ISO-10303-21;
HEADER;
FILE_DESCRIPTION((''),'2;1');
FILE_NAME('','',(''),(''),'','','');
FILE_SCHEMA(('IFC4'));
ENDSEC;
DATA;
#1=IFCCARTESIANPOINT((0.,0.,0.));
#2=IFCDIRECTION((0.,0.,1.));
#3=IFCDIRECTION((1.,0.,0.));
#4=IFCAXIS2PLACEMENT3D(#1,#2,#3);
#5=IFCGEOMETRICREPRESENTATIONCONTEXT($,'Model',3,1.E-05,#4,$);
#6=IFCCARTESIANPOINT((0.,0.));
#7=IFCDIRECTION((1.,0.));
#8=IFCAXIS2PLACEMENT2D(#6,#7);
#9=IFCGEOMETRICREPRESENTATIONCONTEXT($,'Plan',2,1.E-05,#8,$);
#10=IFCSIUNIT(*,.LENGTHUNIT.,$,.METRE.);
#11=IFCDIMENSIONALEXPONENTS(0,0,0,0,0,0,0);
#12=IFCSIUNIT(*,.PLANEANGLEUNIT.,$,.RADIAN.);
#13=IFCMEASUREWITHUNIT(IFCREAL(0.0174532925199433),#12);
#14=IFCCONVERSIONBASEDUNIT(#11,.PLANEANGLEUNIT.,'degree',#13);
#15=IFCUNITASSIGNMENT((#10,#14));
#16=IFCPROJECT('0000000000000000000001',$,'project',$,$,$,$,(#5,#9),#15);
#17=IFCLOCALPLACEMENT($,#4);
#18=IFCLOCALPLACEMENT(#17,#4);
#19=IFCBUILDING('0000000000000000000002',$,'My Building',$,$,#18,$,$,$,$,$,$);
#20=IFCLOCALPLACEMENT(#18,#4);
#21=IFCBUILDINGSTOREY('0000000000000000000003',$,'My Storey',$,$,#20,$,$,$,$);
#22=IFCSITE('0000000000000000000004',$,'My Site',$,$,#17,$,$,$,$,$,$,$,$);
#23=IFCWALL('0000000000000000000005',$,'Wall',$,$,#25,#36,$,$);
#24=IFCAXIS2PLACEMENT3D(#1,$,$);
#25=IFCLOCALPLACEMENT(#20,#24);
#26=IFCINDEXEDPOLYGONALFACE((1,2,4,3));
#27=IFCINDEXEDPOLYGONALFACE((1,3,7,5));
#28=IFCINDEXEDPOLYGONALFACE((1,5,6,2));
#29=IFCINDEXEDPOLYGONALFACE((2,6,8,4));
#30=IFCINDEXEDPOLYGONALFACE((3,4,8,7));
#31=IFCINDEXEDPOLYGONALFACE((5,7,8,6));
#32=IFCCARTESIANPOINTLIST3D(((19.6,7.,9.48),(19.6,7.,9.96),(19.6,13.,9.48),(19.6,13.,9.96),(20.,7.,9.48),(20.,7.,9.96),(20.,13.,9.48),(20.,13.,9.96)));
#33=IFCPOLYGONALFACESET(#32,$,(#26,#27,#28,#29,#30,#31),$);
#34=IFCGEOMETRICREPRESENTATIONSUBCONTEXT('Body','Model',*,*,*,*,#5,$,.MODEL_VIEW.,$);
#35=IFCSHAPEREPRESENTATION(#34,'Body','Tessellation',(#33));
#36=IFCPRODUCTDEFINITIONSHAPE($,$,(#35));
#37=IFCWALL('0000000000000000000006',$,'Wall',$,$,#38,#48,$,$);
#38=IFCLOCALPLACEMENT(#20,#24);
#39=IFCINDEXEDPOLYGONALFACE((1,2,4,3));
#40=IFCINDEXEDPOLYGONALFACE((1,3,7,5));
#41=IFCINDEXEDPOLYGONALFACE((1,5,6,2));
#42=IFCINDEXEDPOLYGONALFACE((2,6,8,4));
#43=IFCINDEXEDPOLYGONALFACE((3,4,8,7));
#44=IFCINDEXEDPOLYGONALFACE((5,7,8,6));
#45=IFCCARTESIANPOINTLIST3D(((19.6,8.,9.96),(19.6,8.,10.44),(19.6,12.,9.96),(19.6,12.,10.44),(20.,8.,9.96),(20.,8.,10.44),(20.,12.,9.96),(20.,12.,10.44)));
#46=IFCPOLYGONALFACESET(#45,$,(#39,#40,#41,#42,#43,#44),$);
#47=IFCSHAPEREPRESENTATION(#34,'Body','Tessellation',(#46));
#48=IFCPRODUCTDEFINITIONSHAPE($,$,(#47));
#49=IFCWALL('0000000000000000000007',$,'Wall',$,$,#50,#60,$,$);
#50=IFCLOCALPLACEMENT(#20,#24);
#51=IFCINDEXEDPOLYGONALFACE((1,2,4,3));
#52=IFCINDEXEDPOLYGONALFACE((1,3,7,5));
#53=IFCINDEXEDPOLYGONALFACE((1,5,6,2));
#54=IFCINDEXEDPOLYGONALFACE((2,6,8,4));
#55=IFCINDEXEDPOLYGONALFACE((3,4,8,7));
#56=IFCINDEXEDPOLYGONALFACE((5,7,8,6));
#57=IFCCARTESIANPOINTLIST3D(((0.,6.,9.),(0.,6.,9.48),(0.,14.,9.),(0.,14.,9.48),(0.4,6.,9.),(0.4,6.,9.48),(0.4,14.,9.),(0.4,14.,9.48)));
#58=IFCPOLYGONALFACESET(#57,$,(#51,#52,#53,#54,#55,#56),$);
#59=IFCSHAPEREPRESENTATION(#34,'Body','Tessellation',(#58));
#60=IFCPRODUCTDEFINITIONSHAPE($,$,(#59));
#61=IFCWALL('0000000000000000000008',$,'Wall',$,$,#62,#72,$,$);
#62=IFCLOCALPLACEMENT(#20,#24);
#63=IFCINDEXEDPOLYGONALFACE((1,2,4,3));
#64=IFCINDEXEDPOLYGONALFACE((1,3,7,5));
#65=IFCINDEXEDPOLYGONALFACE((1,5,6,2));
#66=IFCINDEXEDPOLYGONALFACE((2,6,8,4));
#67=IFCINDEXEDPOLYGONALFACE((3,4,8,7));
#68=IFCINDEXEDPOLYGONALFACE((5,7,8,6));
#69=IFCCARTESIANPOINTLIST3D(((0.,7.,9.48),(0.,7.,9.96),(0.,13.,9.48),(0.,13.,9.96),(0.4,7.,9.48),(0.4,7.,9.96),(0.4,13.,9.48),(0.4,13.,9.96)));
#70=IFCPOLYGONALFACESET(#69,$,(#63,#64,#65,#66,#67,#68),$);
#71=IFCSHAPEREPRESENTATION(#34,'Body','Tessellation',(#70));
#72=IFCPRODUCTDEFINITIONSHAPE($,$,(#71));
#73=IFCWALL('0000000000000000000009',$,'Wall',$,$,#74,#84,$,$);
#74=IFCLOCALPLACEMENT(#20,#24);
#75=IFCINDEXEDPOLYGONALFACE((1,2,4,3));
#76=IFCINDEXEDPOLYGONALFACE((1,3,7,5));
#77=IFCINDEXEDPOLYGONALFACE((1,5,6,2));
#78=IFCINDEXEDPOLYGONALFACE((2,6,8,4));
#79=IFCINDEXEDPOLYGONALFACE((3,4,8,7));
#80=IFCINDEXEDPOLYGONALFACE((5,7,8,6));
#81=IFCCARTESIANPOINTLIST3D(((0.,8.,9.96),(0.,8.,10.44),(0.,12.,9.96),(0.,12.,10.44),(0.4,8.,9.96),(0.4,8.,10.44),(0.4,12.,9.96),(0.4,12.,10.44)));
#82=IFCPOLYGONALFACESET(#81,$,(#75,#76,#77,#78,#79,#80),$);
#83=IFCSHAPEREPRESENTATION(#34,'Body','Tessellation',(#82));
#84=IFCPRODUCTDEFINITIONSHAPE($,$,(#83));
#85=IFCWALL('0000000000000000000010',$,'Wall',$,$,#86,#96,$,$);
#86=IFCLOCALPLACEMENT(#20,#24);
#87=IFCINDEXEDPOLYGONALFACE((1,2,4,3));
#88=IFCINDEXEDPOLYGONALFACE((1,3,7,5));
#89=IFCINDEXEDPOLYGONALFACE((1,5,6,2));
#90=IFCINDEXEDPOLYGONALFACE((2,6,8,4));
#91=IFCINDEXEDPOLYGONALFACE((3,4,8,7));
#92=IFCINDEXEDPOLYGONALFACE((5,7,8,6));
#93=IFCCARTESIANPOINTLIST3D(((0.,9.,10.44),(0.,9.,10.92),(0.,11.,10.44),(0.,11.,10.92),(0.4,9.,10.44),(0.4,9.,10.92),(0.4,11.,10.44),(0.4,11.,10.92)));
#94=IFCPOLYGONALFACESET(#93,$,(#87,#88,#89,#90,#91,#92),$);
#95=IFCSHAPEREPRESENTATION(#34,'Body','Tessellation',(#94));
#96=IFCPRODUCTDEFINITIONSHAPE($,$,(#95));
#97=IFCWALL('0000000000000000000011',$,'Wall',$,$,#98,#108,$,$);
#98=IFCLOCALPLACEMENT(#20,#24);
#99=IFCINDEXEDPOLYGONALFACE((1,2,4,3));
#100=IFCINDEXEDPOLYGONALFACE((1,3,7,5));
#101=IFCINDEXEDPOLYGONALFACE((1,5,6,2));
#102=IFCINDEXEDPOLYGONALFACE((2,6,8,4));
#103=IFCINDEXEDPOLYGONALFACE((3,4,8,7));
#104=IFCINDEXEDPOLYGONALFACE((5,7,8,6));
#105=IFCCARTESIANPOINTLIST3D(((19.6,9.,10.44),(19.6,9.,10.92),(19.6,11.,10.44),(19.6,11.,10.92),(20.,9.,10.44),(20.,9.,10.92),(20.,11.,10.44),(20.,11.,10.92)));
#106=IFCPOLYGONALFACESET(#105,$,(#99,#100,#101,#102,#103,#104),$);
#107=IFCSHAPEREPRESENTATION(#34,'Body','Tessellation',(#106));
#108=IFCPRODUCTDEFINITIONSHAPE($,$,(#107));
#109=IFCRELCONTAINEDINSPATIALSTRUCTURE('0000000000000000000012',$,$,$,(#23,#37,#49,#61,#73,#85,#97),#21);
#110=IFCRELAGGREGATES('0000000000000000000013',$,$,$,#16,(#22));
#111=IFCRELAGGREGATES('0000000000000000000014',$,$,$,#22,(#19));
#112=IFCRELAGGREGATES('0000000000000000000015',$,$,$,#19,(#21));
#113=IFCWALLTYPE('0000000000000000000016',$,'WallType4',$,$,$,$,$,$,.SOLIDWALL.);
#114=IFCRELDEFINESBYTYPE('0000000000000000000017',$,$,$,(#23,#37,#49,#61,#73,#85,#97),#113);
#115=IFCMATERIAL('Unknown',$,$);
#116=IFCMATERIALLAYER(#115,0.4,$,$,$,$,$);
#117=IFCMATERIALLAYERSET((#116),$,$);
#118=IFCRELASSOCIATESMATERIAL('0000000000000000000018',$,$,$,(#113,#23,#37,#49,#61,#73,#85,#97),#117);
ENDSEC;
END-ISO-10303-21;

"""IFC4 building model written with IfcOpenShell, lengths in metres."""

from ifc_helpers import new_model, entity, si_unit, converted_unit, frame, origin_with_axes, origin_2d_with_axis, place, context, subcontext, project, spatial, indexed_curve, outline, extrude, material, layer, layer_set, layer_usage, type_object, element, save


model = new_model("IFC4")

# Units and contexts
model_context = context("Model", 3, precision=1e-05, world=origin_with_axes())
plan_context = context("Plan", 2, precision=1e-05, world=origin_2d_with_axis())
body_context_1 = subcontext(model_context, "Body", "Model", "MODEL_VIEW")
ifc_project = project(units=[si_unit("LENGTHUNIT", "METRE"), converted_unit("PLANEANGLEUNIT", "degree", entity("IfcReal", 0.0174532925199433), si_unit("PLANEANGLEUNIT", "RADIAN"), dimensions=[0, 0, 0, 0, 0, 0, 0])], contexts=[model_context, plan_context])

# Site, building, storey
site_placement = place(None, origin_with_axes())
site = spatial("IfcSite", under=ifc_project, at=site_placement, Name="My Site")
building_placement = place(site_placement, origin_with_axes())
building = spatial("IfcBuilding", under=site, at=building_placement, Name="My Building")
storey_placement = place(building_placement, origin_with_axes())
storey = spatial("IfcBuildingStorey", under=building, at=storey_placement, Name="My Storey")

# Shared definitions
ifc_material = material(Name="Unknown")
ifc_layer = layer(ifc_material, 0.4)
ifc_layer_set = layer_set([ifc_layer])
wall_type = type_object("IfcWallType", Name="WallType4", PredefinedType="SOLIDWALL", material=ifc_layer_set)

# Walls
ifc_layer_usage_1 = layer_usage(ifc_layer_set, "AXIS2", "POSITIVE", 0.0)
wall_1_placement = place(storey_placement, frame((20.0, 7.0, 9.48), z_axis=(0.0, 0.0, 1.0), x_axis=(0.0, 1.0, 0.0)))
element("IfcWall", 1, at=wall_1_placement, inside=storey, type_object=wall_type, material=ifc_layer_usage_1, Name="Wall", context=body_context_1, shape_type="SweptSolid", body=[
    extrude(outline(indexed_curve([(0.0, 0.0), (0.0, 0.4), (6.0, 0.4), (6.0, 0.0), (0.0, 0.0)], self_intersect=False)), origin_with_axes(), (0.0, 0.0, 1.0), 0.48),
])
ifc_layer_usage_2 = layer_usage(ifc_layer_set, "AXIS2", "POSITIVE", 0.0)
wall_2_placement = place(storey_placement, frame((20.0, 8.0, 9.96), z_axis=(0.0, 0.0, 1.0), x_axis=(0.0, 1.0, 0.0)))
element("IfcWall", 2, at=wall_2_placement, inside=storey, type_object=wall_type, material=ifc_layer_usage_2, Name="Wall", context=body_context_1, shape_type="SweptSolid", body=[
    extrude(outline(indexed_curve([(0.0, 0.0), (0.0, 0.4), (4.0, 0.4), (4.0, 0.0), (0.0, 0.0)], self_intersect=False)), origin_with_axes(), (0.0, 0.0, 1.0), 0.48),
])
ifc_layer_usage_3 = layer_usage(ifc_layer_set, "AXIS2", "POSITIVE", 0.0)
wall_3_placement = place(storey_placement, frame((0.4, 6.0, 9.0), z_axis=(0.0, 0.0, 1.0), x_axis=(0.0, 1.0, 0.0)))
element("IfcWall", 3, at=wall_3_placement, inside=storey, type_object=wall_type, material=ifc_layer_usage_3, Name="Wall", context=body_context_1, shape_type="SweptSolid", body=[
    extrude(outline(indexed_curve([(0.0, 0.0), (0.0, 0.4), (8.0, 0.4), (8.0, 0.0), (0.0, 0.0)], self_intersect=False)), origin_with_axes(), (0.0, 0.0, 1.0), 0.48),
])
ifc_layer_usage_4 = layer_usage(ifc_layer_set, "AXIS2", "POSITIVE", 0.0)
wall_4_placement = place(storey_placement, frame((0.4, 7.0, 9.48), z_axis=(0.0, 0.0, 1.0), x_axis=(0.0, 1.0, 0.0)))
element("IfcWall", 4, at=wall_4_placement, inside=storey, type_object=wall_type, material=ifc_layer_usage_4, Name="Wall", context=body_context_1, shape_type="SweptSolid", body=[
    extrude(outline(indexed_curve([(0.0, 0.0), (0.0, 0.4), (6.0, 0.4), (6.0, 0.0), (0.0, 0.0)], self_intersect=False)), origin_with_axes(), (0.0, 0.0, 1.0), 0.48),
])
ifc_layer_usage_5 = layer_usage(ifc_layer_set, "AXIS2", "POSITIVE", 0.0)
wall_5_placement = place(storey_placement, frame((0.4, 8.0, 9.96), z_axis=(0.0, 0.0, 1.0), x_axis=(0.0, 1.0, 0.0)))
element("IfcWall", 5, at=wall_5_placement, inside=storey, type_object=wall_type, material=ifc_layer_usage_5, Name="Wall", context=body_context_1, shape_type="SweptSolid", body=[
    extrude(outline(indexed_curve([(0.0, 0.0), (0.0, 0.4), (4.0, 0.4), (4.0, 0.0), (0.0, 0.0)], self_intersect=False)), origin_with_axes(), (0.0, 0.0, 1.0), 0.48),
])
ifc_layer_usage_6 = layer_usage(ifc_layer_set, "AXIS2", "POSITIVE", 0.0)
wall_6_placement = place(storey_placement, frame((0.4, 9.0, 10.44), z_axis=(0.0, 0.0, 1.0), x_axis=(0.0, 1.0, 0.0)))
element("IfcWall", 6, at=wall_6_placement, inside=storey, type_object=wall_type, material=ifc_layer_usage_6, Name="Wall", context=body_context_1, shape_type="SweptSolid", body=[
    extrude(outline(indexed_curve([(0.0, 0.0), (0.0, 0.4), (2.0, 0.4), (2.0, 0.0), (0.0, 0.0)], self_intersect=False)), origin_with_axes(), (0.0, 0.0, 1.0), 0.48),
])
ifc_layer_usage_7 = layer_usage(ifc_layer_set, "AXIS2", "POSITIVE", 0.0)
wall_7_placement = place(storey_placement, frame((20.0, 9.0, 10.44), z_axis=(0.0, 0.0, 1.0), x_axis=(0.0, 1.0, 0.0)))
element("IfcWall", 7, at=wall_7_placement, inside=storey, type_object=wall_type, material=ifc_layer_usage_7, Name="Wall", context=body_context_1, shape_type="SweptSolid", body=[
    extrude(outline(indexed_curve([(0.0, 0.0), (0.0, 0.4), (2.0, 0.4), (2.0, 0.0), (0.0, 0.0)], self_intersect=False)), origin_with_axes(), (0.0, 0.0, 1.0), 0.48),
])

save(model, "model.ifc")
